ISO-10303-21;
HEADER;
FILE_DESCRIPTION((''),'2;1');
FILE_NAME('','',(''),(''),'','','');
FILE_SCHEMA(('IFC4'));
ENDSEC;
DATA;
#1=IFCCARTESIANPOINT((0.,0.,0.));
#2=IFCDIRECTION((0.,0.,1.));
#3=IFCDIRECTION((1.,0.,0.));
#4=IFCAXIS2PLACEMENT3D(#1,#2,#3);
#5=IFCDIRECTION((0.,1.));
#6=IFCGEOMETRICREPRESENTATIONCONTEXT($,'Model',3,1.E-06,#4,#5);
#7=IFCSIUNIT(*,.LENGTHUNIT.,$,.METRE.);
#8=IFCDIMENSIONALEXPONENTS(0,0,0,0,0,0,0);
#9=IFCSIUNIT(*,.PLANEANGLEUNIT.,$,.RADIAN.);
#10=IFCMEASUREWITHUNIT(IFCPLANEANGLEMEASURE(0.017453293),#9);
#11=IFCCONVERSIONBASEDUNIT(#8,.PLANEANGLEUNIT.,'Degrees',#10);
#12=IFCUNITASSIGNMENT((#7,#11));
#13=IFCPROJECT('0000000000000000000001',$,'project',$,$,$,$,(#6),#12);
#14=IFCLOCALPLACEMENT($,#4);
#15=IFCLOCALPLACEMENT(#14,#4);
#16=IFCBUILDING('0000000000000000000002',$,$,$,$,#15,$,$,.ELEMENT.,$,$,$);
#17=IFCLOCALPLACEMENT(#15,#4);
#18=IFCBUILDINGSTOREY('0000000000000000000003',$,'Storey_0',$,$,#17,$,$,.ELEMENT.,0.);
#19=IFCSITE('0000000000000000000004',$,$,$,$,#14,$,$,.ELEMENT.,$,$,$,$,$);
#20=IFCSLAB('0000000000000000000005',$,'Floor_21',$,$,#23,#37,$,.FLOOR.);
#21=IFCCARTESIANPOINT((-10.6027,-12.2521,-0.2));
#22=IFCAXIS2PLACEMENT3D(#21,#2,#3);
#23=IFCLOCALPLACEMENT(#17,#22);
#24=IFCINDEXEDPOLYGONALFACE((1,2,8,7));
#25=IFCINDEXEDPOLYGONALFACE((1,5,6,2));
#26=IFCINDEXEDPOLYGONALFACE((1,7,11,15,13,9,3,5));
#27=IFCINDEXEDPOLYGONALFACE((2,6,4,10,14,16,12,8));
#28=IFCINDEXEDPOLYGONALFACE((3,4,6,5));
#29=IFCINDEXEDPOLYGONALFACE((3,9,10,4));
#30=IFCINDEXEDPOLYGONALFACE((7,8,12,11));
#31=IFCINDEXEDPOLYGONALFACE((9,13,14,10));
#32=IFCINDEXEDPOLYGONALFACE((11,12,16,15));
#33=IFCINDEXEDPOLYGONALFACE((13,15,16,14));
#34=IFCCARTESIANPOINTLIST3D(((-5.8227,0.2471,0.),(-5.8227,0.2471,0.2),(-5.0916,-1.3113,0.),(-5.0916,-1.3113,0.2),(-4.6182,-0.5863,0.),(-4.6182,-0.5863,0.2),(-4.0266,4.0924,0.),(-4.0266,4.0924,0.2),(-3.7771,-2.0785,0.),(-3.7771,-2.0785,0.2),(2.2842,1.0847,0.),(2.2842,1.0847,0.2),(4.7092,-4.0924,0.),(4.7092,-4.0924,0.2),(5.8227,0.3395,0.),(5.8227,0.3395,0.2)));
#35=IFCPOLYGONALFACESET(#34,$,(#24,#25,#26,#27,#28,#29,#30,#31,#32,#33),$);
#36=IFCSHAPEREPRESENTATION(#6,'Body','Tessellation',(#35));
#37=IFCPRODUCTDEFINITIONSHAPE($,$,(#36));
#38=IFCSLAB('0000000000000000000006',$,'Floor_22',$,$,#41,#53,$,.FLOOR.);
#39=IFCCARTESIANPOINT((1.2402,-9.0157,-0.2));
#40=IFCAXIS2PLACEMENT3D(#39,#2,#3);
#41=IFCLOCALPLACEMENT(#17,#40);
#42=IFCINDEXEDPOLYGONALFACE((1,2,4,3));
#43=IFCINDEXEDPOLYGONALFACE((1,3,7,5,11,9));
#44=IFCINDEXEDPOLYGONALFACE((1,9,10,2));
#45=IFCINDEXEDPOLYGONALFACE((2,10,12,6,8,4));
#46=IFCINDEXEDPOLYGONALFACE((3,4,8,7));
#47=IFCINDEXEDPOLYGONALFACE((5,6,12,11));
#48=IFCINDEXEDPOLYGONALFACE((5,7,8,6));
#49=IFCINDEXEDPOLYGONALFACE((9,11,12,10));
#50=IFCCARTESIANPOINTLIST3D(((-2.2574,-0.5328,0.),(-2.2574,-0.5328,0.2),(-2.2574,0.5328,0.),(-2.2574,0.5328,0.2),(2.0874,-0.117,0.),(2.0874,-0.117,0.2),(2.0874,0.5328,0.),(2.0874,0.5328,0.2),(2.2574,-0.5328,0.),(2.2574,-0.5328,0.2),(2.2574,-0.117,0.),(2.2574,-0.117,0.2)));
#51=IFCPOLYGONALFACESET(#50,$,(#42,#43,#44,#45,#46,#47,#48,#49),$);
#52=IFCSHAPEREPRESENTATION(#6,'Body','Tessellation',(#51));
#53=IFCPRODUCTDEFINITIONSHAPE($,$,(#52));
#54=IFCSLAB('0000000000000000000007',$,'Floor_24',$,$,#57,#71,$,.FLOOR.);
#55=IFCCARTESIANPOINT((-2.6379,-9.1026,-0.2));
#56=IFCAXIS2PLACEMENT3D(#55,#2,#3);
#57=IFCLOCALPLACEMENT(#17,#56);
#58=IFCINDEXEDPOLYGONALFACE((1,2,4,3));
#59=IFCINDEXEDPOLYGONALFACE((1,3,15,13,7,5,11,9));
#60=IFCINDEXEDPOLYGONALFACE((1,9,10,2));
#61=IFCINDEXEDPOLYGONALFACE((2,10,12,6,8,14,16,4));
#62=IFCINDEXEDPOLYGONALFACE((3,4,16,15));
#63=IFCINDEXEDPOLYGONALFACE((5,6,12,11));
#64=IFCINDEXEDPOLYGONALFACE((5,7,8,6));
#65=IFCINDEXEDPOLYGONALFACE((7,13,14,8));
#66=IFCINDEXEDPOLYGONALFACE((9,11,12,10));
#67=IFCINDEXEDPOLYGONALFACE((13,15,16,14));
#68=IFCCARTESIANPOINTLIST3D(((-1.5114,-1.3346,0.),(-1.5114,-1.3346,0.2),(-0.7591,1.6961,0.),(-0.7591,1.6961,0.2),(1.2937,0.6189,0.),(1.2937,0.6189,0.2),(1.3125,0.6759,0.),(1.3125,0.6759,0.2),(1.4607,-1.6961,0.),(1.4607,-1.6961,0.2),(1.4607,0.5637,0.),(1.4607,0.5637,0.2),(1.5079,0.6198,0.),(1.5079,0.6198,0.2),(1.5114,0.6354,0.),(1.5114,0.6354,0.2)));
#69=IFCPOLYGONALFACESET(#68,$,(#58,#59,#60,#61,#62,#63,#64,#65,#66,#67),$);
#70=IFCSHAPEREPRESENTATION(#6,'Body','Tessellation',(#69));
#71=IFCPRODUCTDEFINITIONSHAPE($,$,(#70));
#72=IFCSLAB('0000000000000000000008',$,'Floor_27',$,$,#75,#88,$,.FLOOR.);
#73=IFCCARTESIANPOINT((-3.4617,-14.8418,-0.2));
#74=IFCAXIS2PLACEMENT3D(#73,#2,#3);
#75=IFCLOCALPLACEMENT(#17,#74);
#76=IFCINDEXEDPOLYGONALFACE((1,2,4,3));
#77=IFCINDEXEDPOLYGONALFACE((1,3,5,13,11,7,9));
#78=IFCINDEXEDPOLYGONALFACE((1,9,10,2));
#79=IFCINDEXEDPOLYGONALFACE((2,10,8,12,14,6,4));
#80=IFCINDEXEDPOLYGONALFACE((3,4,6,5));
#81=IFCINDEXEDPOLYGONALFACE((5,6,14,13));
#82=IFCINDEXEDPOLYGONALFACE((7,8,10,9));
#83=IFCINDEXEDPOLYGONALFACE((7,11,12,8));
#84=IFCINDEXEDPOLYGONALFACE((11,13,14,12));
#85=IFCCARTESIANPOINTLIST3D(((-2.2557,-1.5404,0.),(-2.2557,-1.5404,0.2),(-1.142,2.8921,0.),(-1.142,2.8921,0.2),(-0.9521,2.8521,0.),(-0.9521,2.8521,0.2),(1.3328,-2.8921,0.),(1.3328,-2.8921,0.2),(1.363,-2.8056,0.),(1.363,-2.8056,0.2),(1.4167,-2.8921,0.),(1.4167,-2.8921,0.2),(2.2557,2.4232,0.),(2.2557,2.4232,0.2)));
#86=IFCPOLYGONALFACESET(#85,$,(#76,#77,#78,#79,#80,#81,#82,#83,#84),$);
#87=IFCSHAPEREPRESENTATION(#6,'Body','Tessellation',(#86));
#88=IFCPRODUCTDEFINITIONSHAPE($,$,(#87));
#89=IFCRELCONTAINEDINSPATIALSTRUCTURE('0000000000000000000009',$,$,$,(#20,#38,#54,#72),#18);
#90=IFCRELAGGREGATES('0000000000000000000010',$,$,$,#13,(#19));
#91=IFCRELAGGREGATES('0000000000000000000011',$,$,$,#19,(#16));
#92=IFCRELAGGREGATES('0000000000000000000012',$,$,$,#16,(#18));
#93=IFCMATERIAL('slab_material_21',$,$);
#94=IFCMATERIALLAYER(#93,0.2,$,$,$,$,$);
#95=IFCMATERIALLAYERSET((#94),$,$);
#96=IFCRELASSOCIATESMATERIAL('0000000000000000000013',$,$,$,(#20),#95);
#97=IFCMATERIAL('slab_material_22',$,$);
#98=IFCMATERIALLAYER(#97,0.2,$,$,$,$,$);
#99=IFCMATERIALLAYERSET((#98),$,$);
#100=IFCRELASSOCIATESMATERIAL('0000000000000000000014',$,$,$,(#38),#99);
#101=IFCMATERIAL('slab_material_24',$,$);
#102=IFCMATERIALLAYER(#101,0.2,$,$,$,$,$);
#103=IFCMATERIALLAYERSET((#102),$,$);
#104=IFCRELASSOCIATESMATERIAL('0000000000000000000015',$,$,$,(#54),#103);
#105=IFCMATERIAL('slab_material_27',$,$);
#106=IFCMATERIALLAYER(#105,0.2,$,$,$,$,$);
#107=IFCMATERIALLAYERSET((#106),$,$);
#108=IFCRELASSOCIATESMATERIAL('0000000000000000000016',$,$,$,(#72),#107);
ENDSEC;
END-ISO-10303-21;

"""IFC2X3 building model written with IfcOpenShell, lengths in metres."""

from ifc_helpers import new_model, entity, si_unit, converted_unit, direction, frame, origin_with_axes, place, context, project, spatial, polyline, outline, extrude, material, layer, layer_set, layer_usage, element, save


model = new_model("IFC2X3")

# Units and contexts
model_context = context("Model", 3, precision=1e-06, world=origin_with_axes(), true_north=direction((0.0, 1.0)))
ifc_project = project(units=[si_unit("LENGTHUNIT", "METRE"), converted_unit("PLANEANGLEUNIT", "Degrees", entity("IfcPlaneAngleMeasure", 0.017453293), si_unit("PLANEANGLEUNIT", "RADIAN"), dimensions=[0, 0, 0, 0, 0, 0, 0])], contexts=[model_context])

# Site, building, storey
site_placement = place(None, origin_with_axes())
site = spatial("IfcSite", under=ifc_project, at=site_placement, CompositionType="ELEMENT")
building_placement = place(site_placement, origin_with_axes())
building = spatial("IfcBuilding", under=site, at=building_placement, CompositionType="ELEMENT")
storey_placement = place(building_placement, origin_with_axes())
storey = spatial("IfcBuildingStorey", under=building, at=storey_placement, Name="Storey_0", CompositionType="ELEMENT", Elevation=0.0)

# Slabs
ifc_material_1 = material(Name="slab_material_21")
ifc_layer_1 = layer(ifc_material_1, 0.2)
ifc_layer_set_1 = layer_set([ifc_layer_1])
ifc_layer_usage_1 = layer_usage(ifc_layer_set_1, "AXIS3", "POSITIVE", 0.0)
slab_1_placement = place(storey_placement, frame((-10.6027, -12.2521, -0.2), z_axis=(0.0, 0.0, 1.0), x_axis=(1.0, 0.0, 0.0)))
element("IfcSlab", 1, at=slab_1_placement, inside=storey, material=ifc_layer_usage_1, Name="Floor_21", PredefinedType="FLOOR", context=model_context, shape_type="SweptSolid", body=[
    extrude(outline(polyline([(-4.0266, 4.0924), (2.2842, 1.0847), (5.8227, 0.3395), (4.7092, -4.0924), (-3.7771, -2.0785), (-5.0916, -1.3113), (-4.6182, -0.5863), (-5.8227, 0.2471), (-4.0266, 4.0924)])), origin_with_axes(), (0.0, 0.0, 1.0), 0.2),
])
ifc_material_2 = material(Name="slab_material_22")
ifc_layer_2 = layer(ifc_material_2, 0.2)
ifc_layer_set_2 = layer_set([ifc_layer_2])
ifc_layer_usage_2 = layer_usage(ifc_layer_set_2, "AXIS3", "POSITIVE", 0.0)
slab_2_placement = place(storey_placement, frame((1.2402, -9.0157, -0.2), z_axis=(0.0, 0.0, 1.0), x_axis=(1.0, 0.0, 0.0)))
element("IfcSlab", 2, at=slab_2_placement, inside=storey, material=ifc_layer_usage_2, Name="Floor_22", PredefinedType="FLOOR", context=model_context, shape_type="SweptSolid", body=[
    extrude(outline(polyline([(2.0874, -0.117), (2.2574, -0.117), (2.2574, -0.5328), (-2.2574, -0.5328), (-2.2574, 0.5328), (2.0874, 0.5328), (2.0874, -0.117)])), origin_with_axes(), (0.0, 0.0, 1.0), 0.2),
])
ifc_material_3 = material(Name="slab_material_24")
ifc_layer_3 = layer(ifc_material_3, 0.2)
ifc_layer_set_3 = layer_set([ifc_layer_3])
ifc_layer_usage_3 = layer_usage(ifc_layer_set_3, "AXIS3", "POSITIVE", 0.0)
slab_3_placement = place(storey_placement, frame((-2.6379, -9.1026, -0.2), z_axis=(0.0, 0.0, 1.0), x_axis=(1.0, 0.0, 0.0)))
element("IfcSlab", 3, at=slab_3_placement, inside=storey, material=ifc_layer_usage_3, Name="Floor_24", PredefinedType="FLOOR", context=model_context, shape_type="SweptSolid", body=[
    extrude(outline(polyline([(1.5114, 0.6354), (1.5079, 0.6198), (1.3125, 0.6759), (1.2937, 0.6189), (1.4607, 0.5637), (1.4607, -1.6961), (-1.5114, -1.3346), (-0.7591, 1.6961), (1.5114, 0.6354)])), origin_with_axes(), (0.0, 0.0, 1.0), 0.2),
])
ifc_material_4 = material(Name="slab_material_27")
ifc_layer_4 = layer(ifc_material_4, 0.2)
ifc_layer_set_4 = layer_set([ifc_layer_4])
ifc_layer_usage_4 = layer_usage(ifc_layer_set_4, "AXIS3", "POSITIVE", 0.0)
slab_4_placement = place(storey_placement, frame((-3.4617, -14.8418, -0.2), z_axis=(0.0, 0.0, 1.0), x_axis=(1.0, 0.0, 0.0)))
element("IfcSlab", 4, at=slab_4_placement, inside=storey, material=ifc_layer_usage_4, Name="Floor_27", PredefinedType="FLOOR", context=model_context, shape_type="SweptSolid", body=[
    extrude(outline(polyline([(-1.142, 2.8921), (-0.9521, 2.8521), (2.2557, 2.4232), (1.4167, -2.8921), (1.3328, -2.8921), (1.363, -2.8056), (-2.2557, -1.5404), (-1.142, 2.8921)])), origin_with_axes(), (0.0, 0.0, 1.0), 0.2),
])

save(model, "model.ifc")
